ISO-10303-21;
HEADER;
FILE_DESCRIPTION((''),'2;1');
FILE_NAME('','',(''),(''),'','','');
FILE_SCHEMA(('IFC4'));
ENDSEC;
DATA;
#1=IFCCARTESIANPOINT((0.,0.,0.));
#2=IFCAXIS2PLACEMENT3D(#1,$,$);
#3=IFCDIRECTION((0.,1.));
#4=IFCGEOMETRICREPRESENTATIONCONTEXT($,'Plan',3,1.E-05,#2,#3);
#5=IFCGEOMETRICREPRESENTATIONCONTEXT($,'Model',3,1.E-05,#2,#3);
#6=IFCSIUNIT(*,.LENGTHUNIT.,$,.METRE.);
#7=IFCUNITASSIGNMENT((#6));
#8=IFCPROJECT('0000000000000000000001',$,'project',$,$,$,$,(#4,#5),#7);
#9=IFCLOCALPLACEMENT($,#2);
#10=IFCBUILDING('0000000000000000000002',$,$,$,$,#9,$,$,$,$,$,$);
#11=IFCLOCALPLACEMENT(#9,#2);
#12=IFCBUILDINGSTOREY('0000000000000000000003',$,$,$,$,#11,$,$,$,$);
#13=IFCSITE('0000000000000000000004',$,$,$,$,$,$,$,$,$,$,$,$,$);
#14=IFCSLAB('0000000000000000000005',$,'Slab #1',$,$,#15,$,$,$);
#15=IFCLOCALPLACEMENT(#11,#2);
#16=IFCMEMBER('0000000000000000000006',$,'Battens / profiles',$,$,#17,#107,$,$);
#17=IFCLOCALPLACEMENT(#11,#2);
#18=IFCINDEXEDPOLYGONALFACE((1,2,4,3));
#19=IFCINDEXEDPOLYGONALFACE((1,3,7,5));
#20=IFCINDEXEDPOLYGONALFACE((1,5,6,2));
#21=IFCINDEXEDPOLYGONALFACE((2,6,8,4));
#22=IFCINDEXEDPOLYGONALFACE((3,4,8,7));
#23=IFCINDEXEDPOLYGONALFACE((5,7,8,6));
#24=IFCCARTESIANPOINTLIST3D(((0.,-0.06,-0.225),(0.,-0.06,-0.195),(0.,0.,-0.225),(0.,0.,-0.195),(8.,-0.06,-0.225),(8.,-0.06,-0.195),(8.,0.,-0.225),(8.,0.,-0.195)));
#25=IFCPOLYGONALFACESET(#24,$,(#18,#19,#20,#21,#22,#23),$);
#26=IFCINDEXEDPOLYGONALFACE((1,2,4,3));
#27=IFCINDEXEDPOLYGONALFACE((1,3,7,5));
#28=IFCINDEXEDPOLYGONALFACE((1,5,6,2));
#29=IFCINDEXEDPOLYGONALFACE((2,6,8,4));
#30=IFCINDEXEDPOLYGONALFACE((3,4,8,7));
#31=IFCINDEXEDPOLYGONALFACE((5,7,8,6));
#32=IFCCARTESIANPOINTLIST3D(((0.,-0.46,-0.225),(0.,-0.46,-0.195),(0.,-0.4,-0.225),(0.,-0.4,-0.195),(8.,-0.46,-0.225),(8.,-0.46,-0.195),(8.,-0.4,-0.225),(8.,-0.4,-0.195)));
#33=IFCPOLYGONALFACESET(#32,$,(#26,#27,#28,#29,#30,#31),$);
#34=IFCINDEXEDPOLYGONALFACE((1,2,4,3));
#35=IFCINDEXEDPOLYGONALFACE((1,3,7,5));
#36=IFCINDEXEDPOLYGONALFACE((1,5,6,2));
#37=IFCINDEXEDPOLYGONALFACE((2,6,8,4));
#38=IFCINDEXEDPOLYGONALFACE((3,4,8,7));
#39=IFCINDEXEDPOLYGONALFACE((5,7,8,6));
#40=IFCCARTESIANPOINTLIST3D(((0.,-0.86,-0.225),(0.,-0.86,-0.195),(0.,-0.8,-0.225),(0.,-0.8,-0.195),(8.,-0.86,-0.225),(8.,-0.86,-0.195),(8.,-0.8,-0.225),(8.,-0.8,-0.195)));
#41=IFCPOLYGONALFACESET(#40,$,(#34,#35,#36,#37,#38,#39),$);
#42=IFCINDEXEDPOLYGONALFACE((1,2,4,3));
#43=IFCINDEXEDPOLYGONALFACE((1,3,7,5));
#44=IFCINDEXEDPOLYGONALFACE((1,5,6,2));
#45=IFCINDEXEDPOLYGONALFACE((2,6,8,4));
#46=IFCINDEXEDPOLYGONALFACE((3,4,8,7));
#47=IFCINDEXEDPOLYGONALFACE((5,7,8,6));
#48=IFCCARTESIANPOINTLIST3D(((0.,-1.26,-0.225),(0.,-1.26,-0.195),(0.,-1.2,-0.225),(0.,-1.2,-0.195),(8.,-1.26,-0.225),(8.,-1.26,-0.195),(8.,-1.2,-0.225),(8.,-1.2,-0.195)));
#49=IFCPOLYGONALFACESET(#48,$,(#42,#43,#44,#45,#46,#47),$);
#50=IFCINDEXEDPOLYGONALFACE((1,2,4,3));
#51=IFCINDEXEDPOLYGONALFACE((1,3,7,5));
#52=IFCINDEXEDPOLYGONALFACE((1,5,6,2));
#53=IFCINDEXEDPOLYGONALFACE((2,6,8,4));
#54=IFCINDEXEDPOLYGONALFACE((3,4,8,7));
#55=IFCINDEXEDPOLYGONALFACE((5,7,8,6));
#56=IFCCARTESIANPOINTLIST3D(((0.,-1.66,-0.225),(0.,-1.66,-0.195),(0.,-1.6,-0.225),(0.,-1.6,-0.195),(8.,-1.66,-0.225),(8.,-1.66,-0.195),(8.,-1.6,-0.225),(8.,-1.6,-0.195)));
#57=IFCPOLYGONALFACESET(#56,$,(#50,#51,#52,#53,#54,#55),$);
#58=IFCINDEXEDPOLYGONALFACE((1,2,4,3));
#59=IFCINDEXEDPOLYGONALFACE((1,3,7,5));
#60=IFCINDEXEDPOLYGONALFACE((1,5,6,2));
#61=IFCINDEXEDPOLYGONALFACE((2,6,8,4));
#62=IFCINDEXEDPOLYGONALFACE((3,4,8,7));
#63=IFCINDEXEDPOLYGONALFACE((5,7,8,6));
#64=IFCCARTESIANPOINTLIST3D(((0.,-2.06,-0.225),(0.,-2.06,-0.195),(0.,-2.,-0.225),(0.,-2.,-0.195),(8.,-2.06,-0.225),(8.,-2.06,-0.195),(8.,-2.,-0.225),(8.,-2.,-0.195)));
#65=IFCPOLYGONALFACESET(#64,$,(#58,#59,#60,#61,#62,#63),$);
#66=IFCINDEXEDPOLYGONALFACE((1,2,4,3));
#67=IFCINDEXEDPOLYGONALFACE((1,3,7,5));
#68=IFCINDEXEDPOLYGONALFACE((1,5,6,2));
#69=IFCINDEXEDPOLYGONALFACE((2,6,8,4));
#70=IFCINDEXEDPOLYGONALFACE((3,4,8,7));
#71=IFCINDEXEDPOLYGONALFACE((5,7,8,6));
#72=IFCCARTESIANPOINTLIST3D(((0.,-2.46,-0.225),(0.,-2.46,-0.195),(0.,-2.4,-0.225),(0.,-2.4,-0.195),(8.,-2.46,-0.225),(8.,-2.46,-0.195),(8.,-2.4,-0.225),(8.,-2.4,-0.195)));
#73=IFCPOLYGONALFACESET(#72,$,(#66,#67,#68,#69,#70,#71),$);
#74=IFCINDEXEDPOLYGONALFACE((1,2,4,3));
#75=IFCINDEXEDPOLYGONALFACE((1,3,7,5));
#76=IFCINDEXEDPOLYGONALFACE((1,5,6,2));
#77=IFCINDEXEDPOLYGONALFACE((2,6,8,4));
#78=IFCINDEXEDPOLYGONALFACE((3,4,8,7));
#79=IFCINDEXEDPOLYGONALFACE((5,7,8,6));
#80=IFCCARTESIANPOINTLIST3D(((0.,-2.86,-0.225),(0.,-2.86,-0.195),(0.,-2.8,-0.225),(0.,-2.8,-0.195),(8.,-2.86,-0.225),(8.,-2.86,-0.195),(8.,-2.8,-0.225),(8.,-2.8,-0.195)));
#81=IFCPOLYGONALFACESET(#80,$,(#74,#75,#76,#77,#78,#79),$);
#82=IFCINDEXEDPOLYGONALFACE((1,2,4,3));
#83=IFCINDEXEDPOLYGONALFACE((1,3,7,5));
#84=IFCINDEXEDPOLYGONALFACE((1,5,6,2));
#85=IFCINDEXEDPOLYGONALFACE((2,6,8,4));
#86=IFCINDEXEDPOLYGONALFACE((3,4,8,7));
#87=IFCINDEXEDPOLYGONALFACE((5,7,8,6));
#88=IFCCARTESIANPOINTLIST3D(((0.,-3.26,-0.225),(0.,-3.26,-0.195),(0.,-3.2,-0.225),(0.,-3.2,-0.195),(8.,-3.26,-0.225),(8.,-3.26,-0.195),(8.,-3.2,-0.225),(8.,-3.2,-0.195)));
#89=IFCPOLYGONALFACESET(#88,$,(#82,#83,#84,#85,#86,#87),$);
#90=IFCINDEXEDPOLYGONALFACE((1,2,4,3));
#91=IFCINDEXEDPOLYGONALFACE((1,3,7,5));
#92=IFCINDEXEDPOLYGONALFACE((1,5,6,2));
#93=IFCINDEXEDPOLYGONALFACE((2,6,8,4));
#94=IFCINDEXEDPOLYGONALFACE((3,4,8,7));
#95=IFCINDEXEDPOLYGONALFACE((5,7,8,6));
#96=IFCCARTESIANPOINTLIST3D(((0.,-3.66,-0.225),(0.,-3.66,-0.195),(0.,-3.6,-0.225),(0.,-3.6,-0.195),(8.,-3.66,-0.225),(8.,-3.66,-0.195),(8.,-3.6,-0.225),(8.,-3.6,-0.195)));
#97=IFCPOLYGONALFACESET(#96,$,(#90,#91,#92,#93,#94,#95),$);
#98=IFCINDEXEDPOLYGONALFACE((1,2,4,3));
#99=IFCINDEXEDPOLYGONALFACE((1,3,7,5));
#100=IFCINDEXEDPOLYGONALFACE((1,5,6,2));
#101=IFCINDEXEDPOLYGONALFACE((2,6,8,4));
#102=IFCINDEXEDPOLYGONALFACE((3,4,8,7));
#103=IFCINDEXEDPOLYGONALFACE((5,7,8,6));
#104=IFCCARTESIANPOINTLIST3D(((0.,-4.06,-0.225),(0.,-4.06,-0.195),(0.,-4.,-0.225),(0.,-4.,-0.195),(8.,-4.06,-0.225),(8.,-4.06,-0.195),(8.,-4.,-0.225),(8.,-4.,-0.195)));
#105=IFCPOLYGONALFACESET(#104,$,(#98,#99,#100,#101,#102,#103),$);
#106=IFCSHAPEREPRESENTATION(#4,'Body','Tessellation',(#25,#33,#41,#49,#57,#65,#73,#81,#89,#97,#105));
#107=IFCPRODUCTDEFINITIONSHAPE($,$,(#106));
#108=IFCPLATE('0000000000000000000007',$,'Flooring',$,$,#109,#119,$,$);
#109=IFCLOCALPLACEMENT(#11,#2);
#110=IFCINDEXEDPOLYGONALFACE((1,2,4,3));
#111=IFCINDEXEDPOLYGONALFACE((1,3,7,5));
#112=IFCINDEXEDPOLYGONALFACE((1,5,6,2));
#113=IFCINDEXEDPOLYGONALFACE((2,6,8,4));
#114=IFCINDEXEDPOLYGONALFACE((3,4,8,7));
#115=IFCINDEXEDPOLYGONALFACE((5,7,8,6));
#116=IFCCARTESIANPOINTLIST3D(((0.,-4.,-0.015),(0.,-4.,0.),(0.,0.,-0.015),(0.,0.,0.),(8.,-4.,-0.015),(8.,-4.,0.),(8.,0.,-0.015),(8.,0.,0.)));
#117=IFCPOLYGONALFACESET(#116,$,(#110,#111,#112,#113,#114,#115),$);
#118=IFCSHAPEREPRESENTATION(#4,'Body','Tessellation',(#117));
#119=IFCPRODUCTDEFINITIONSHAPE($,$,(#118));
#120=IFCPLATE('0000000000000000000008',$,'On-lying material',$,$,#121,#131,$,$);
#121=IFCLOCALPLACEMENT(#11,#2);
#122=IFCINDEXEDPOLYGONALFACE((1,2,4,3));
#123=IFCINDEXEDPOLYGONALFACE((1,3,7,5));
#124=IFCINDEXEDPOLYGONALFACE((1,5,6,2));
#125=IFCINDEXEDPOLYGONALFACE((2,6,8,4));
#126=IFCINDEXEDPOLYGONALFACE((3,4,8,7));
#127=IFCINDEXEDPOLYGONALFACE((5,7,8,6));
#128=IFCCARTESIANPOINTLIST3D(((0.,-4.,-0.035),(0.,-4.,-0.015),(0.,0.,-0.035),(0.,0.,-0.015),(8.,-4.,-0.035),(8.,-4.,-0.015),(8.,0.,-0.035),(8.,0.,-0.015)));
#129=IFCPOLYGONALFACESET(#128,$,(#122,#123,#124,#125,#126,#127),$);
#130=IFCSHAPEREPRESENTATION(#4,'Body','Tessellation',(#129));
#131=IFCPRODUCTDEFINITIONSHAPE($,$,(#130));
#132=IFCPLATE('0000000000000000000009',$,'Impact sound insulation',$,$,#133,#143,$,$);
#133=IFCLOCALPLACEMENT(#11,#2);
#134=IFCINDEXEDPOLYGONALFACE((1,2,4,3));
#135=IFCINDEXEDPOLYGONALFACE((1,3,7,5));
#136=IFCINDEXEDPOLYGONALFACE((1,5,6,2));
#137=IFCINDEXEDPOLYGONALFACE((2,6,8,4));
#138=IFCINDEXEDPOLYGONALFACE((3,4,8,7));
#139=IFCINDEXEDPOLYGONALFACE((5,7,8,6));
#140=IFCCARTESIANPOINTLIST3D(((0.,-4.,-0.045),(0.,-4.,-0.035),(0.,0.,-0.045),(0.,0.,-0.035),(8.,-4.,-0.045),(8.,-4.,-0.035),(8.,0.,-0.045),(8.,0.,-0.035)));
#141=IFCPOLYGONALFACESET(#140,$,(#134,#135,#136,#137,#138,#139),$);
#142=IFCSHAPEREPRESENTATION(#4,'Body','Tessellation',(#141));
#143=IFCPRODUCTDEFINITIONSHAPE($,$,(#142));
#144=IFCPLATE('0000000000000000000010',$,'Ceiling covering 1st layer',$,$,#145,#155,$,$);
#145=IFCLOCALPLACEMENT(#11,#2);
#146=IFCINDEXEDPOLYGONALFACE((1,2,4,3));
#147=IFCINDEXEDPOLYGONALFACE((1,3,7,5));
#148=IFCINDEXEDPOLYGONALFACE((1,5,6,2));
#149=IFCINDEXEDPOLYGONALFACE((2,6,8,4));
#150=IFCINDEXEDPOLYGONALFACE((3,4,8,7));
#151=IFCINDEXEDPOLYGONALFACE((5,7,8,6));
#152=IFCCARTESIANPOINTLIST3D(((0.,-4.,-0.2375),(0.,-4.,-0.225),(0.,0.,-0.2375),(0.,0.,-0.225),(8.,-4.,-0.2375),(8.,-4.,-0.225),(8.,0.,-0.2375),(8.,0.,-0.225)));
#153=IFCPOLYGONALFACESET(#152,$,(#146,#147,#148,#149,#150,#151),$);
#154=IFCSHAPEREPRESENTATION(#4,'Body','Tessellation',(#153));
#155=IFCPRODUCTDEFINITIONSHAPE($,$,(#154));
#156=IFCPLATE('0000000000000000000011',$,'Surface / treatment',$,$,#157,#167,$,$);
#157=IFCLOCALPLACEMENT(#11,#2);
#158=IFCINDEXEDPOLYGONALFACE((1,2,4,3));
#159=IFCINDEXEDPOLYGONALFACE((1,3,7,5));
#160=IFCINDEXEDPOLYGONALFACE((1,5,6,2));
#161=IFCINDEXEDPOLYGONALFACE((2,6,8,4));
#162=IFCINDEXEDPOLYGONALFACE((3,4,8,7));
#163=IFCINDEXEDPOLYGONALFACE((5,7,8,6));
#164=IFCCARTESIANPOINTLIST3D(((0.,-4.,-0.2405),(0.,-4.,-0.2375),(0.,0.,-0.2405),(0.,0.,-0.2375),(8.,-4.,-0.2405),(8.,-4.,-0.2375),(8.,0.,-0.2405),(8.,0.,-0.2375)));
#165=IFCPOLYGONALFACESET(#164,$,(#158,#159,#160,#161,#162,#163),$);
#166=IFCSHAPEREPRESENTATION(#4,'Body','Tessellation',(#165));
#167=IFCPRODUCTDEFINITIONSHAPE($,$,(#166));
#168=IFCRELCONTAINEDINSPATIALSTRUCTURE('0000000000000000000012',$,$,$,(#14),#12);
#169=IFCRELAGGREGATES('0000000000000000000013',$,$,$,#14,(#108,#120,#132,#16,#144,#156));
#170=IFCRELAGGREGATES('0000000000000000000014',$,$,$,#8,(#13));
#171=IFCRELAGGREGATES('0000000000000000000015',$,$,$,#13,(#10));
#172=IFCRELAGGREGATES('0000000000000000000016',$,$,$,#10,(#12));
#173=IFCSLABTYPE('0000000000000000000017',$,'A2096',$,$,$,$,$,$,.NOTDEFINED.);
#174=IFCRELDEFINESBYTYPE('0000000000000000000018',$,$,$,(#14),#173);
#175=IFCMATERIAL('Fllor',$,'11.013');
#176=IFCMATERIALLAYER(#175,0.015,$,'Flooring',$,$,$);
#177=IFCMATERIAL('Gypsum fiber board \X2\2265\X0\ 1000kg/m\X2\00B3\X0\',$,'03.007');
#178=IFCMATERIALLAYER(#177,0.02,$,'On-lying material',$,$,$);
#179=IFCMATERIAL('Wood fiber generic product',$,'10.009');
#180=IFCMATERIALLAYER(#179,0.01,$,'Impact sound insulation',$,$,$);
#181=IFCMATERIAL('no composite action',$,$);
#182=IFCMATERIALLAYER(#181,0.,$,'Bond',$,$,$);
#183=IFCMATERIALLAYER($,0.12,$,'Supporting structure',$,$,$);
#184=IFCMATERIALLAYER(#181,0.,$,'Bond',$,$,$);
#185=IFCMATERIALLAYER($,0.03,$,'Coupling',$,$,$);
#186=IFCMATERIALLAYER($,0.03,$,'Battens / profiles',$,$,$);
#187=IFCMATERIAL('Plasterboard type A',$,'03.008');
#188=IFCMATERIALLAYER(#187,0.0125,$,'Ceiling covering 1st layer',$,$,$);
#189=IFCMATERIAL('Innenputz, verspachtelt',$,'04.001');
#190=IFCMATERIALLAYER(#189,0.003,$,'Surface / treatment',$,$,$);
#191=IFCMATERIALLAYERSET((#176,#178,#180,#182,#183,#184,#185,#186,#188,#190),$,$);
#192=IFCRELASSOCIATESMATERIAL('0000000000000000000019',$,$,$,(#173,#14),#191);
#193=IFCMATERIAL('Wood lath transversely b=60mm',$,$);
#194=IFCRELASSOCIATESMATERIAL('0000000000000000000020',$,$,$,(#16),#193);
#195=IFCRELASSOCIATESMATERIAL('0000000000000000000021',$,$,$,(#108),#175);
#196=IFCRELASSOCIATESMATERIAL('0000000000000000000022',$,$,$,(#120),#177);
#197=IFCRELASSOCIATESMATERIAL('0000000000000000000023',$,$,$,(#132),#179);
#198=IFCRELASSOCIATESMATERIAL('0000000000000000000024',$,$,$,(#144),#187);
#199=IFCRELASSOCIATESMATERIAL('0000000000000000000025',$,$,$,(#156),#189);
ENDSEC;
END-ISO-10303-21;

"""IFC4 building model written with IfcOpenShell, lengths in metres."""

from ifc_helpers import new_model, si_unit, direction, frame, frame_2d, origin, origin_with_axes, place, context, project, spatial, rectangle, extrude, material, layer, layer_set, type_object, element, aggregate, save


model = new_model("IFC4")

# Units and contexts
plan_context = context("Plan", 3, precision=1e-05, world=origin(), true_north=direction((0.0, 1.0)))
model_context = context("Model", 3, precision=1e-05, world=origin(), true_north=direction((0.0, 1.0)))
ifc_project = project(units=[si_unit("LENGTHUNIT", "METRE")], contexts=[plan_context, model_context])

# Site, building, storey
site = spatial("IfcSite", under=ifc_project)
building_placement = place(None, origin())
building = spatial("IfcBuilding", under=site, at=building_placement)
storey_placement = place(building_placement, origin())
storey = spatial("IfcBuildingStorey", under=building, at=storey_placement)

# Slab, member, plates
ifc_material_1 = material(Name="Fllor", Category="11.013")
ifc_layer_1 = layer(ifc_material_1, 0.015, Name="Flooring")
ifc_material_2 = material(Name="Gypsum fiber board ≥ 1000kg/m³", Category="03.007")
ifc_layer_2 = layer(ifc_material_2, 0.02, Name="On-lying material")
ifc_material_3 = material(Name="Wood fiber generic product", Category="10.009")
ifc_layer_3 = layer(ifc_material_3, 0.01, Name="Impact sound insulation")
ifc_material_4 = material(Name="no composite action")
ifc_layer_4 = layer(ifc_material_4, 0.0, Name="Bond")
ifc_layer_5 = layer(None, 0.12, Name="Supporting structure")
ifc_layer_6 = layer(ifc_material_4, 0.0, Name="Bond")
ifc_layer_7 = layer(None, 0.03, Name="Coupling")
ifc_layer_8 = layer(None, 0.03, Name="Battens / profiles")
ifc_material_5 = material(Name="Plasterboard type A", Category="03.008")
ifc_layer_9 = layer(ifc_material_5, 0.0125, Name="Ceiling covering 1st layer")
ifc_material_6 = material(Name="Innenputz, verspachtelt", Category="04.001")
ifc_layer_10 = layer(ifc_material_6, 0.003, Name="Surface / treatment")
ifc_layer_set = layer_set([ifc_layer_1, ifc_layer_2, ifc_layer_3, ifc_layer_4, ifc_layer_5, ifc_layer_6, ifc_layer_7, ifc_layer_8, ifc_layer_9, ifc_layer_10])
slab_type = type_object("IfcSlabType", Name="A2096", PredefinedType="NOTDEFINED", material=ifc_layer_set)
slab_placement = place(None, frame((0.0, 0.0, 0.0), z_axis=(0.0, 0.0, -1.0), x_axis=(1.0, 0.0, 0.0)))
slab = element("IfcSlab", 1, at=slab_placement, inside=storey, type_object=slab_type, material=ifc_layer_set, Name="Slab #1")
ifc_material_7 = material(Name="Wood lath transversely b=60mm")
member_1_placement = place(slab_placement, origin())
member_1 = element("IfcMember", 2, at=member_1_placement, material=ifc_material_7, Name="Battens / profiles", context=plan_context, shape_type="SweptSolid", body=[
    extrude(rectangle(XDim=0.06, YDim=0.03, at=frame_2d((0.03, 0.015), x_axis=(1.0, 0.0))), frame((0.0, 0.0, 0.195), z_axis=(1.0, 0.0, 0.0), x_axis=(0.0, 1.0, 0.0)), (0.0, 0.0, 1.0), 8.0),
    extrude(rectangle(XDim=0.06, YDim=0.03, at=frame_2d((0.03, 0.015), x_axis=(1.0, 0.0))), frame((0.0, 0.4, 0.195), z_axis=(1.0, 0.0, 0.0), x_axis=(0.0, 1.0, 0.0)), (0.0, 0.0, 1.0), 8.0),
    extrude(rectangle(XDim=0.06, YDim=0.03, at=frame_2d((0.03, 0.015), x_axis=(1.0, 0.0))), frame((0.0, 0.8, 0.195), z_axis=(1.0, 0.0, 0.0), x_axis=(0.0, 1.0, 0.0)), (0.0, 0.0, 1.0), 8.0),
    extrude(rectangle(XDim=0.06, YDim=0.03, at=frame_2d((0.03, 0.015), x_axis=(1.0, 0.0))), frame((0.0, 1.2, 0.195), z_axis=(1.0, 0.0, 0.0), x_axis=(0.0, 1.0, 0.0)), (0.0, 0.0, 1.0), 8.0),
    extrude(rectangle(XDim=0.06, YDim=0.03, at=frame_2d((0.03, 0.015), x_axis=(1.0, 0.0))), frame((0.0, 1.6, 0.195), z_axis=(1.0, 0.0, 0.0), x_axis=(0.0, 1.0, 0.0)), (0.0, 0.0, 1.0), 8.0),
    extrude(rectangle(XDim=0.06, YDim=0.03, at=frame_2d((0.03, 0.015), x_axis=(1.0, 0.0))), frame((0.0, 2.0, 0.195), z_axis=(1.0, 0.0, 0.0), x_axis=(0.0, 1.0, 0.0)), (0.0, 0.0, 1.0), 8.0),
    extrude(rectangle(XDim=0.06, YDim=0.03, at=frame_2d((0.03, 0.015), x_axis=(1.0, 0.0))), frame((0.0, 2.4, 0.195), z_axis=(1.0, 0.0, 0.0), x_axis=(0.0, 1.0, 0.0)), (0.0, 0.0, 1.0), 8.0),
    extrude(rectangle(XDim=0.06, YDim=0.03, at=frame_2d((0.03, 0.015), x_axis=(1.0, 0.0))), frame((0.0, 2.8, 0.195), z_axis=(1.0, 0.0, 0.0), x_axis=(0.0, 1.0, 0.0)), (0.0, 0.0, 1.0), 8.0),
    extrude(rectangle(XDim=0.06, YDim=0.03, at=frame_2d((0.03, 0.015), x_axis=(1.0, 0.0))), frame((0.0, 3.2, 0.195), z_axis=(1.0, 0.0, 0.0), x_axis=(0.0, 1.0, 0.0)), (0.0, 0.0, 1.0), 8.0),
    extrude(rectangle(XDim=0.06, YDim=0.03, at=frame_2d((0.03, 0.015), x_axis=(1.0, 0.0))), frame((0.0, 3.6, 0.195), z_axis=(1.0, 0.0, 0.0), x_axis=(0.0, 1.0, 0.0)), (0.0, 0.0, 1.0), 8.0),
    extrude(rectangle(XDim=0.06, YDim=0.03, at=frame_2d((0.03, 0.015), x_axis=(1.0, 0.0))), frame((0.0, 4.0, 0.195), z_axis=(1.0, 0.0, 0.0), x_axis=(0.0, 1.0, 0.0)), (0.0, 0.0, 1.0), 8.0),
])
plate_1_placement = place(slab_placement, origin())
plate_1 = element("IfcPlate", 3, at=plate_1_placement, material=ifc_material_1, Name="Flooring", context=plan_context, shape_type="SweptSolid", body=[
    extrude(rectangle(XDim=8.0, YDim=4.0, at=frame_2d((4.0, 2.0), x_axis=(1.0, 0.0))), origin_with_axes(), (0.0, 0.0, 1.0), 0.015),
])
plate_2_placement = place(slab_placement, origin())
plate_2 = element("IfcPlate", 4, at=plate_2_placement, material=ifc_material_2, Name="On-lying material", context=plan_context, shape_type="SweptSolid", body=[
    extrude(rectangle(XDim=8.0, YDim=4.0, at=frame_2d((4.0, 2.0), x_axis=(1.0, 0.0))), frame((0.0, 0.0, 0.015), z_axis=(0.0, 0.0, 1.0), x_axis=(1.0, 0.0, 0.0)), (0.0, 0.0, 1.0), 0.02),
])
plate_3_placement = place(slab_placement, origin())
plate_3 = element("IfcPlate", 5, at=plate_3_placement, material=ifc_material_3, Name="Impact sound insulation", context=plan_context, shape_type="SweptSolid", body=[
    extrude(rectangle(XDim=8.0, YDim=4.0, at=frame_2d((4.0, 2.0), x_axis=(1.0, 0.0))), frame((0.0, 0.0, 0.035), z_axis=(0.0, 0.0, 1.0), x_axis=(1.0, 0.0, 0.0)), (0.0, 0.0, 1.0), 0.01),
])
plate_4_placement = place(slab_placement, origin())
plate_4 = element("IfcPlate", 6, at=plate_4_placement, material=ifc_material_5, Name="Ceiling covering 1st layer", context=plan_context, shape_type="SweptSolid", body=[
    extrude(rectangle(XDim=8.0, YDim=4.0, at=frame_2d((4.0, 2.0), x_axis=(1.0, 0.0))), frame((0.0, 0.0, 0.225), z_axis=(0.0, 0.0, 1.0), x_axis=(1.0, 0.0, 0.0)), (0.0, 0.0, 1.0), 0.0125),
])
plate_5_placement = place(slab_placement, origin())
plate_5 = element("IfcPlate", 7, at=plate_5_placement, material=ifc_material_6, Name="Surface / treatment", context=plan_context, shape_type="SweptSolid", body=[
    extrude(rectangle(XDim=8.0, YDim=4.0, at=frame_2d((4.0, 2.0), x_axis=(1.0, 0.0))), frame((0.0, 0.0, 0.2375), z_axis=(0.0, 0.0, 1.0), x_axis=(1.0, 0.0, 0.0)), (0.0, 0.0, 1.0), 0.003),
])
aggregate(slab, [plate_1, plate_2, plate_3, member_1, plate_4, plate_5])

save(model, "model.ifc")
